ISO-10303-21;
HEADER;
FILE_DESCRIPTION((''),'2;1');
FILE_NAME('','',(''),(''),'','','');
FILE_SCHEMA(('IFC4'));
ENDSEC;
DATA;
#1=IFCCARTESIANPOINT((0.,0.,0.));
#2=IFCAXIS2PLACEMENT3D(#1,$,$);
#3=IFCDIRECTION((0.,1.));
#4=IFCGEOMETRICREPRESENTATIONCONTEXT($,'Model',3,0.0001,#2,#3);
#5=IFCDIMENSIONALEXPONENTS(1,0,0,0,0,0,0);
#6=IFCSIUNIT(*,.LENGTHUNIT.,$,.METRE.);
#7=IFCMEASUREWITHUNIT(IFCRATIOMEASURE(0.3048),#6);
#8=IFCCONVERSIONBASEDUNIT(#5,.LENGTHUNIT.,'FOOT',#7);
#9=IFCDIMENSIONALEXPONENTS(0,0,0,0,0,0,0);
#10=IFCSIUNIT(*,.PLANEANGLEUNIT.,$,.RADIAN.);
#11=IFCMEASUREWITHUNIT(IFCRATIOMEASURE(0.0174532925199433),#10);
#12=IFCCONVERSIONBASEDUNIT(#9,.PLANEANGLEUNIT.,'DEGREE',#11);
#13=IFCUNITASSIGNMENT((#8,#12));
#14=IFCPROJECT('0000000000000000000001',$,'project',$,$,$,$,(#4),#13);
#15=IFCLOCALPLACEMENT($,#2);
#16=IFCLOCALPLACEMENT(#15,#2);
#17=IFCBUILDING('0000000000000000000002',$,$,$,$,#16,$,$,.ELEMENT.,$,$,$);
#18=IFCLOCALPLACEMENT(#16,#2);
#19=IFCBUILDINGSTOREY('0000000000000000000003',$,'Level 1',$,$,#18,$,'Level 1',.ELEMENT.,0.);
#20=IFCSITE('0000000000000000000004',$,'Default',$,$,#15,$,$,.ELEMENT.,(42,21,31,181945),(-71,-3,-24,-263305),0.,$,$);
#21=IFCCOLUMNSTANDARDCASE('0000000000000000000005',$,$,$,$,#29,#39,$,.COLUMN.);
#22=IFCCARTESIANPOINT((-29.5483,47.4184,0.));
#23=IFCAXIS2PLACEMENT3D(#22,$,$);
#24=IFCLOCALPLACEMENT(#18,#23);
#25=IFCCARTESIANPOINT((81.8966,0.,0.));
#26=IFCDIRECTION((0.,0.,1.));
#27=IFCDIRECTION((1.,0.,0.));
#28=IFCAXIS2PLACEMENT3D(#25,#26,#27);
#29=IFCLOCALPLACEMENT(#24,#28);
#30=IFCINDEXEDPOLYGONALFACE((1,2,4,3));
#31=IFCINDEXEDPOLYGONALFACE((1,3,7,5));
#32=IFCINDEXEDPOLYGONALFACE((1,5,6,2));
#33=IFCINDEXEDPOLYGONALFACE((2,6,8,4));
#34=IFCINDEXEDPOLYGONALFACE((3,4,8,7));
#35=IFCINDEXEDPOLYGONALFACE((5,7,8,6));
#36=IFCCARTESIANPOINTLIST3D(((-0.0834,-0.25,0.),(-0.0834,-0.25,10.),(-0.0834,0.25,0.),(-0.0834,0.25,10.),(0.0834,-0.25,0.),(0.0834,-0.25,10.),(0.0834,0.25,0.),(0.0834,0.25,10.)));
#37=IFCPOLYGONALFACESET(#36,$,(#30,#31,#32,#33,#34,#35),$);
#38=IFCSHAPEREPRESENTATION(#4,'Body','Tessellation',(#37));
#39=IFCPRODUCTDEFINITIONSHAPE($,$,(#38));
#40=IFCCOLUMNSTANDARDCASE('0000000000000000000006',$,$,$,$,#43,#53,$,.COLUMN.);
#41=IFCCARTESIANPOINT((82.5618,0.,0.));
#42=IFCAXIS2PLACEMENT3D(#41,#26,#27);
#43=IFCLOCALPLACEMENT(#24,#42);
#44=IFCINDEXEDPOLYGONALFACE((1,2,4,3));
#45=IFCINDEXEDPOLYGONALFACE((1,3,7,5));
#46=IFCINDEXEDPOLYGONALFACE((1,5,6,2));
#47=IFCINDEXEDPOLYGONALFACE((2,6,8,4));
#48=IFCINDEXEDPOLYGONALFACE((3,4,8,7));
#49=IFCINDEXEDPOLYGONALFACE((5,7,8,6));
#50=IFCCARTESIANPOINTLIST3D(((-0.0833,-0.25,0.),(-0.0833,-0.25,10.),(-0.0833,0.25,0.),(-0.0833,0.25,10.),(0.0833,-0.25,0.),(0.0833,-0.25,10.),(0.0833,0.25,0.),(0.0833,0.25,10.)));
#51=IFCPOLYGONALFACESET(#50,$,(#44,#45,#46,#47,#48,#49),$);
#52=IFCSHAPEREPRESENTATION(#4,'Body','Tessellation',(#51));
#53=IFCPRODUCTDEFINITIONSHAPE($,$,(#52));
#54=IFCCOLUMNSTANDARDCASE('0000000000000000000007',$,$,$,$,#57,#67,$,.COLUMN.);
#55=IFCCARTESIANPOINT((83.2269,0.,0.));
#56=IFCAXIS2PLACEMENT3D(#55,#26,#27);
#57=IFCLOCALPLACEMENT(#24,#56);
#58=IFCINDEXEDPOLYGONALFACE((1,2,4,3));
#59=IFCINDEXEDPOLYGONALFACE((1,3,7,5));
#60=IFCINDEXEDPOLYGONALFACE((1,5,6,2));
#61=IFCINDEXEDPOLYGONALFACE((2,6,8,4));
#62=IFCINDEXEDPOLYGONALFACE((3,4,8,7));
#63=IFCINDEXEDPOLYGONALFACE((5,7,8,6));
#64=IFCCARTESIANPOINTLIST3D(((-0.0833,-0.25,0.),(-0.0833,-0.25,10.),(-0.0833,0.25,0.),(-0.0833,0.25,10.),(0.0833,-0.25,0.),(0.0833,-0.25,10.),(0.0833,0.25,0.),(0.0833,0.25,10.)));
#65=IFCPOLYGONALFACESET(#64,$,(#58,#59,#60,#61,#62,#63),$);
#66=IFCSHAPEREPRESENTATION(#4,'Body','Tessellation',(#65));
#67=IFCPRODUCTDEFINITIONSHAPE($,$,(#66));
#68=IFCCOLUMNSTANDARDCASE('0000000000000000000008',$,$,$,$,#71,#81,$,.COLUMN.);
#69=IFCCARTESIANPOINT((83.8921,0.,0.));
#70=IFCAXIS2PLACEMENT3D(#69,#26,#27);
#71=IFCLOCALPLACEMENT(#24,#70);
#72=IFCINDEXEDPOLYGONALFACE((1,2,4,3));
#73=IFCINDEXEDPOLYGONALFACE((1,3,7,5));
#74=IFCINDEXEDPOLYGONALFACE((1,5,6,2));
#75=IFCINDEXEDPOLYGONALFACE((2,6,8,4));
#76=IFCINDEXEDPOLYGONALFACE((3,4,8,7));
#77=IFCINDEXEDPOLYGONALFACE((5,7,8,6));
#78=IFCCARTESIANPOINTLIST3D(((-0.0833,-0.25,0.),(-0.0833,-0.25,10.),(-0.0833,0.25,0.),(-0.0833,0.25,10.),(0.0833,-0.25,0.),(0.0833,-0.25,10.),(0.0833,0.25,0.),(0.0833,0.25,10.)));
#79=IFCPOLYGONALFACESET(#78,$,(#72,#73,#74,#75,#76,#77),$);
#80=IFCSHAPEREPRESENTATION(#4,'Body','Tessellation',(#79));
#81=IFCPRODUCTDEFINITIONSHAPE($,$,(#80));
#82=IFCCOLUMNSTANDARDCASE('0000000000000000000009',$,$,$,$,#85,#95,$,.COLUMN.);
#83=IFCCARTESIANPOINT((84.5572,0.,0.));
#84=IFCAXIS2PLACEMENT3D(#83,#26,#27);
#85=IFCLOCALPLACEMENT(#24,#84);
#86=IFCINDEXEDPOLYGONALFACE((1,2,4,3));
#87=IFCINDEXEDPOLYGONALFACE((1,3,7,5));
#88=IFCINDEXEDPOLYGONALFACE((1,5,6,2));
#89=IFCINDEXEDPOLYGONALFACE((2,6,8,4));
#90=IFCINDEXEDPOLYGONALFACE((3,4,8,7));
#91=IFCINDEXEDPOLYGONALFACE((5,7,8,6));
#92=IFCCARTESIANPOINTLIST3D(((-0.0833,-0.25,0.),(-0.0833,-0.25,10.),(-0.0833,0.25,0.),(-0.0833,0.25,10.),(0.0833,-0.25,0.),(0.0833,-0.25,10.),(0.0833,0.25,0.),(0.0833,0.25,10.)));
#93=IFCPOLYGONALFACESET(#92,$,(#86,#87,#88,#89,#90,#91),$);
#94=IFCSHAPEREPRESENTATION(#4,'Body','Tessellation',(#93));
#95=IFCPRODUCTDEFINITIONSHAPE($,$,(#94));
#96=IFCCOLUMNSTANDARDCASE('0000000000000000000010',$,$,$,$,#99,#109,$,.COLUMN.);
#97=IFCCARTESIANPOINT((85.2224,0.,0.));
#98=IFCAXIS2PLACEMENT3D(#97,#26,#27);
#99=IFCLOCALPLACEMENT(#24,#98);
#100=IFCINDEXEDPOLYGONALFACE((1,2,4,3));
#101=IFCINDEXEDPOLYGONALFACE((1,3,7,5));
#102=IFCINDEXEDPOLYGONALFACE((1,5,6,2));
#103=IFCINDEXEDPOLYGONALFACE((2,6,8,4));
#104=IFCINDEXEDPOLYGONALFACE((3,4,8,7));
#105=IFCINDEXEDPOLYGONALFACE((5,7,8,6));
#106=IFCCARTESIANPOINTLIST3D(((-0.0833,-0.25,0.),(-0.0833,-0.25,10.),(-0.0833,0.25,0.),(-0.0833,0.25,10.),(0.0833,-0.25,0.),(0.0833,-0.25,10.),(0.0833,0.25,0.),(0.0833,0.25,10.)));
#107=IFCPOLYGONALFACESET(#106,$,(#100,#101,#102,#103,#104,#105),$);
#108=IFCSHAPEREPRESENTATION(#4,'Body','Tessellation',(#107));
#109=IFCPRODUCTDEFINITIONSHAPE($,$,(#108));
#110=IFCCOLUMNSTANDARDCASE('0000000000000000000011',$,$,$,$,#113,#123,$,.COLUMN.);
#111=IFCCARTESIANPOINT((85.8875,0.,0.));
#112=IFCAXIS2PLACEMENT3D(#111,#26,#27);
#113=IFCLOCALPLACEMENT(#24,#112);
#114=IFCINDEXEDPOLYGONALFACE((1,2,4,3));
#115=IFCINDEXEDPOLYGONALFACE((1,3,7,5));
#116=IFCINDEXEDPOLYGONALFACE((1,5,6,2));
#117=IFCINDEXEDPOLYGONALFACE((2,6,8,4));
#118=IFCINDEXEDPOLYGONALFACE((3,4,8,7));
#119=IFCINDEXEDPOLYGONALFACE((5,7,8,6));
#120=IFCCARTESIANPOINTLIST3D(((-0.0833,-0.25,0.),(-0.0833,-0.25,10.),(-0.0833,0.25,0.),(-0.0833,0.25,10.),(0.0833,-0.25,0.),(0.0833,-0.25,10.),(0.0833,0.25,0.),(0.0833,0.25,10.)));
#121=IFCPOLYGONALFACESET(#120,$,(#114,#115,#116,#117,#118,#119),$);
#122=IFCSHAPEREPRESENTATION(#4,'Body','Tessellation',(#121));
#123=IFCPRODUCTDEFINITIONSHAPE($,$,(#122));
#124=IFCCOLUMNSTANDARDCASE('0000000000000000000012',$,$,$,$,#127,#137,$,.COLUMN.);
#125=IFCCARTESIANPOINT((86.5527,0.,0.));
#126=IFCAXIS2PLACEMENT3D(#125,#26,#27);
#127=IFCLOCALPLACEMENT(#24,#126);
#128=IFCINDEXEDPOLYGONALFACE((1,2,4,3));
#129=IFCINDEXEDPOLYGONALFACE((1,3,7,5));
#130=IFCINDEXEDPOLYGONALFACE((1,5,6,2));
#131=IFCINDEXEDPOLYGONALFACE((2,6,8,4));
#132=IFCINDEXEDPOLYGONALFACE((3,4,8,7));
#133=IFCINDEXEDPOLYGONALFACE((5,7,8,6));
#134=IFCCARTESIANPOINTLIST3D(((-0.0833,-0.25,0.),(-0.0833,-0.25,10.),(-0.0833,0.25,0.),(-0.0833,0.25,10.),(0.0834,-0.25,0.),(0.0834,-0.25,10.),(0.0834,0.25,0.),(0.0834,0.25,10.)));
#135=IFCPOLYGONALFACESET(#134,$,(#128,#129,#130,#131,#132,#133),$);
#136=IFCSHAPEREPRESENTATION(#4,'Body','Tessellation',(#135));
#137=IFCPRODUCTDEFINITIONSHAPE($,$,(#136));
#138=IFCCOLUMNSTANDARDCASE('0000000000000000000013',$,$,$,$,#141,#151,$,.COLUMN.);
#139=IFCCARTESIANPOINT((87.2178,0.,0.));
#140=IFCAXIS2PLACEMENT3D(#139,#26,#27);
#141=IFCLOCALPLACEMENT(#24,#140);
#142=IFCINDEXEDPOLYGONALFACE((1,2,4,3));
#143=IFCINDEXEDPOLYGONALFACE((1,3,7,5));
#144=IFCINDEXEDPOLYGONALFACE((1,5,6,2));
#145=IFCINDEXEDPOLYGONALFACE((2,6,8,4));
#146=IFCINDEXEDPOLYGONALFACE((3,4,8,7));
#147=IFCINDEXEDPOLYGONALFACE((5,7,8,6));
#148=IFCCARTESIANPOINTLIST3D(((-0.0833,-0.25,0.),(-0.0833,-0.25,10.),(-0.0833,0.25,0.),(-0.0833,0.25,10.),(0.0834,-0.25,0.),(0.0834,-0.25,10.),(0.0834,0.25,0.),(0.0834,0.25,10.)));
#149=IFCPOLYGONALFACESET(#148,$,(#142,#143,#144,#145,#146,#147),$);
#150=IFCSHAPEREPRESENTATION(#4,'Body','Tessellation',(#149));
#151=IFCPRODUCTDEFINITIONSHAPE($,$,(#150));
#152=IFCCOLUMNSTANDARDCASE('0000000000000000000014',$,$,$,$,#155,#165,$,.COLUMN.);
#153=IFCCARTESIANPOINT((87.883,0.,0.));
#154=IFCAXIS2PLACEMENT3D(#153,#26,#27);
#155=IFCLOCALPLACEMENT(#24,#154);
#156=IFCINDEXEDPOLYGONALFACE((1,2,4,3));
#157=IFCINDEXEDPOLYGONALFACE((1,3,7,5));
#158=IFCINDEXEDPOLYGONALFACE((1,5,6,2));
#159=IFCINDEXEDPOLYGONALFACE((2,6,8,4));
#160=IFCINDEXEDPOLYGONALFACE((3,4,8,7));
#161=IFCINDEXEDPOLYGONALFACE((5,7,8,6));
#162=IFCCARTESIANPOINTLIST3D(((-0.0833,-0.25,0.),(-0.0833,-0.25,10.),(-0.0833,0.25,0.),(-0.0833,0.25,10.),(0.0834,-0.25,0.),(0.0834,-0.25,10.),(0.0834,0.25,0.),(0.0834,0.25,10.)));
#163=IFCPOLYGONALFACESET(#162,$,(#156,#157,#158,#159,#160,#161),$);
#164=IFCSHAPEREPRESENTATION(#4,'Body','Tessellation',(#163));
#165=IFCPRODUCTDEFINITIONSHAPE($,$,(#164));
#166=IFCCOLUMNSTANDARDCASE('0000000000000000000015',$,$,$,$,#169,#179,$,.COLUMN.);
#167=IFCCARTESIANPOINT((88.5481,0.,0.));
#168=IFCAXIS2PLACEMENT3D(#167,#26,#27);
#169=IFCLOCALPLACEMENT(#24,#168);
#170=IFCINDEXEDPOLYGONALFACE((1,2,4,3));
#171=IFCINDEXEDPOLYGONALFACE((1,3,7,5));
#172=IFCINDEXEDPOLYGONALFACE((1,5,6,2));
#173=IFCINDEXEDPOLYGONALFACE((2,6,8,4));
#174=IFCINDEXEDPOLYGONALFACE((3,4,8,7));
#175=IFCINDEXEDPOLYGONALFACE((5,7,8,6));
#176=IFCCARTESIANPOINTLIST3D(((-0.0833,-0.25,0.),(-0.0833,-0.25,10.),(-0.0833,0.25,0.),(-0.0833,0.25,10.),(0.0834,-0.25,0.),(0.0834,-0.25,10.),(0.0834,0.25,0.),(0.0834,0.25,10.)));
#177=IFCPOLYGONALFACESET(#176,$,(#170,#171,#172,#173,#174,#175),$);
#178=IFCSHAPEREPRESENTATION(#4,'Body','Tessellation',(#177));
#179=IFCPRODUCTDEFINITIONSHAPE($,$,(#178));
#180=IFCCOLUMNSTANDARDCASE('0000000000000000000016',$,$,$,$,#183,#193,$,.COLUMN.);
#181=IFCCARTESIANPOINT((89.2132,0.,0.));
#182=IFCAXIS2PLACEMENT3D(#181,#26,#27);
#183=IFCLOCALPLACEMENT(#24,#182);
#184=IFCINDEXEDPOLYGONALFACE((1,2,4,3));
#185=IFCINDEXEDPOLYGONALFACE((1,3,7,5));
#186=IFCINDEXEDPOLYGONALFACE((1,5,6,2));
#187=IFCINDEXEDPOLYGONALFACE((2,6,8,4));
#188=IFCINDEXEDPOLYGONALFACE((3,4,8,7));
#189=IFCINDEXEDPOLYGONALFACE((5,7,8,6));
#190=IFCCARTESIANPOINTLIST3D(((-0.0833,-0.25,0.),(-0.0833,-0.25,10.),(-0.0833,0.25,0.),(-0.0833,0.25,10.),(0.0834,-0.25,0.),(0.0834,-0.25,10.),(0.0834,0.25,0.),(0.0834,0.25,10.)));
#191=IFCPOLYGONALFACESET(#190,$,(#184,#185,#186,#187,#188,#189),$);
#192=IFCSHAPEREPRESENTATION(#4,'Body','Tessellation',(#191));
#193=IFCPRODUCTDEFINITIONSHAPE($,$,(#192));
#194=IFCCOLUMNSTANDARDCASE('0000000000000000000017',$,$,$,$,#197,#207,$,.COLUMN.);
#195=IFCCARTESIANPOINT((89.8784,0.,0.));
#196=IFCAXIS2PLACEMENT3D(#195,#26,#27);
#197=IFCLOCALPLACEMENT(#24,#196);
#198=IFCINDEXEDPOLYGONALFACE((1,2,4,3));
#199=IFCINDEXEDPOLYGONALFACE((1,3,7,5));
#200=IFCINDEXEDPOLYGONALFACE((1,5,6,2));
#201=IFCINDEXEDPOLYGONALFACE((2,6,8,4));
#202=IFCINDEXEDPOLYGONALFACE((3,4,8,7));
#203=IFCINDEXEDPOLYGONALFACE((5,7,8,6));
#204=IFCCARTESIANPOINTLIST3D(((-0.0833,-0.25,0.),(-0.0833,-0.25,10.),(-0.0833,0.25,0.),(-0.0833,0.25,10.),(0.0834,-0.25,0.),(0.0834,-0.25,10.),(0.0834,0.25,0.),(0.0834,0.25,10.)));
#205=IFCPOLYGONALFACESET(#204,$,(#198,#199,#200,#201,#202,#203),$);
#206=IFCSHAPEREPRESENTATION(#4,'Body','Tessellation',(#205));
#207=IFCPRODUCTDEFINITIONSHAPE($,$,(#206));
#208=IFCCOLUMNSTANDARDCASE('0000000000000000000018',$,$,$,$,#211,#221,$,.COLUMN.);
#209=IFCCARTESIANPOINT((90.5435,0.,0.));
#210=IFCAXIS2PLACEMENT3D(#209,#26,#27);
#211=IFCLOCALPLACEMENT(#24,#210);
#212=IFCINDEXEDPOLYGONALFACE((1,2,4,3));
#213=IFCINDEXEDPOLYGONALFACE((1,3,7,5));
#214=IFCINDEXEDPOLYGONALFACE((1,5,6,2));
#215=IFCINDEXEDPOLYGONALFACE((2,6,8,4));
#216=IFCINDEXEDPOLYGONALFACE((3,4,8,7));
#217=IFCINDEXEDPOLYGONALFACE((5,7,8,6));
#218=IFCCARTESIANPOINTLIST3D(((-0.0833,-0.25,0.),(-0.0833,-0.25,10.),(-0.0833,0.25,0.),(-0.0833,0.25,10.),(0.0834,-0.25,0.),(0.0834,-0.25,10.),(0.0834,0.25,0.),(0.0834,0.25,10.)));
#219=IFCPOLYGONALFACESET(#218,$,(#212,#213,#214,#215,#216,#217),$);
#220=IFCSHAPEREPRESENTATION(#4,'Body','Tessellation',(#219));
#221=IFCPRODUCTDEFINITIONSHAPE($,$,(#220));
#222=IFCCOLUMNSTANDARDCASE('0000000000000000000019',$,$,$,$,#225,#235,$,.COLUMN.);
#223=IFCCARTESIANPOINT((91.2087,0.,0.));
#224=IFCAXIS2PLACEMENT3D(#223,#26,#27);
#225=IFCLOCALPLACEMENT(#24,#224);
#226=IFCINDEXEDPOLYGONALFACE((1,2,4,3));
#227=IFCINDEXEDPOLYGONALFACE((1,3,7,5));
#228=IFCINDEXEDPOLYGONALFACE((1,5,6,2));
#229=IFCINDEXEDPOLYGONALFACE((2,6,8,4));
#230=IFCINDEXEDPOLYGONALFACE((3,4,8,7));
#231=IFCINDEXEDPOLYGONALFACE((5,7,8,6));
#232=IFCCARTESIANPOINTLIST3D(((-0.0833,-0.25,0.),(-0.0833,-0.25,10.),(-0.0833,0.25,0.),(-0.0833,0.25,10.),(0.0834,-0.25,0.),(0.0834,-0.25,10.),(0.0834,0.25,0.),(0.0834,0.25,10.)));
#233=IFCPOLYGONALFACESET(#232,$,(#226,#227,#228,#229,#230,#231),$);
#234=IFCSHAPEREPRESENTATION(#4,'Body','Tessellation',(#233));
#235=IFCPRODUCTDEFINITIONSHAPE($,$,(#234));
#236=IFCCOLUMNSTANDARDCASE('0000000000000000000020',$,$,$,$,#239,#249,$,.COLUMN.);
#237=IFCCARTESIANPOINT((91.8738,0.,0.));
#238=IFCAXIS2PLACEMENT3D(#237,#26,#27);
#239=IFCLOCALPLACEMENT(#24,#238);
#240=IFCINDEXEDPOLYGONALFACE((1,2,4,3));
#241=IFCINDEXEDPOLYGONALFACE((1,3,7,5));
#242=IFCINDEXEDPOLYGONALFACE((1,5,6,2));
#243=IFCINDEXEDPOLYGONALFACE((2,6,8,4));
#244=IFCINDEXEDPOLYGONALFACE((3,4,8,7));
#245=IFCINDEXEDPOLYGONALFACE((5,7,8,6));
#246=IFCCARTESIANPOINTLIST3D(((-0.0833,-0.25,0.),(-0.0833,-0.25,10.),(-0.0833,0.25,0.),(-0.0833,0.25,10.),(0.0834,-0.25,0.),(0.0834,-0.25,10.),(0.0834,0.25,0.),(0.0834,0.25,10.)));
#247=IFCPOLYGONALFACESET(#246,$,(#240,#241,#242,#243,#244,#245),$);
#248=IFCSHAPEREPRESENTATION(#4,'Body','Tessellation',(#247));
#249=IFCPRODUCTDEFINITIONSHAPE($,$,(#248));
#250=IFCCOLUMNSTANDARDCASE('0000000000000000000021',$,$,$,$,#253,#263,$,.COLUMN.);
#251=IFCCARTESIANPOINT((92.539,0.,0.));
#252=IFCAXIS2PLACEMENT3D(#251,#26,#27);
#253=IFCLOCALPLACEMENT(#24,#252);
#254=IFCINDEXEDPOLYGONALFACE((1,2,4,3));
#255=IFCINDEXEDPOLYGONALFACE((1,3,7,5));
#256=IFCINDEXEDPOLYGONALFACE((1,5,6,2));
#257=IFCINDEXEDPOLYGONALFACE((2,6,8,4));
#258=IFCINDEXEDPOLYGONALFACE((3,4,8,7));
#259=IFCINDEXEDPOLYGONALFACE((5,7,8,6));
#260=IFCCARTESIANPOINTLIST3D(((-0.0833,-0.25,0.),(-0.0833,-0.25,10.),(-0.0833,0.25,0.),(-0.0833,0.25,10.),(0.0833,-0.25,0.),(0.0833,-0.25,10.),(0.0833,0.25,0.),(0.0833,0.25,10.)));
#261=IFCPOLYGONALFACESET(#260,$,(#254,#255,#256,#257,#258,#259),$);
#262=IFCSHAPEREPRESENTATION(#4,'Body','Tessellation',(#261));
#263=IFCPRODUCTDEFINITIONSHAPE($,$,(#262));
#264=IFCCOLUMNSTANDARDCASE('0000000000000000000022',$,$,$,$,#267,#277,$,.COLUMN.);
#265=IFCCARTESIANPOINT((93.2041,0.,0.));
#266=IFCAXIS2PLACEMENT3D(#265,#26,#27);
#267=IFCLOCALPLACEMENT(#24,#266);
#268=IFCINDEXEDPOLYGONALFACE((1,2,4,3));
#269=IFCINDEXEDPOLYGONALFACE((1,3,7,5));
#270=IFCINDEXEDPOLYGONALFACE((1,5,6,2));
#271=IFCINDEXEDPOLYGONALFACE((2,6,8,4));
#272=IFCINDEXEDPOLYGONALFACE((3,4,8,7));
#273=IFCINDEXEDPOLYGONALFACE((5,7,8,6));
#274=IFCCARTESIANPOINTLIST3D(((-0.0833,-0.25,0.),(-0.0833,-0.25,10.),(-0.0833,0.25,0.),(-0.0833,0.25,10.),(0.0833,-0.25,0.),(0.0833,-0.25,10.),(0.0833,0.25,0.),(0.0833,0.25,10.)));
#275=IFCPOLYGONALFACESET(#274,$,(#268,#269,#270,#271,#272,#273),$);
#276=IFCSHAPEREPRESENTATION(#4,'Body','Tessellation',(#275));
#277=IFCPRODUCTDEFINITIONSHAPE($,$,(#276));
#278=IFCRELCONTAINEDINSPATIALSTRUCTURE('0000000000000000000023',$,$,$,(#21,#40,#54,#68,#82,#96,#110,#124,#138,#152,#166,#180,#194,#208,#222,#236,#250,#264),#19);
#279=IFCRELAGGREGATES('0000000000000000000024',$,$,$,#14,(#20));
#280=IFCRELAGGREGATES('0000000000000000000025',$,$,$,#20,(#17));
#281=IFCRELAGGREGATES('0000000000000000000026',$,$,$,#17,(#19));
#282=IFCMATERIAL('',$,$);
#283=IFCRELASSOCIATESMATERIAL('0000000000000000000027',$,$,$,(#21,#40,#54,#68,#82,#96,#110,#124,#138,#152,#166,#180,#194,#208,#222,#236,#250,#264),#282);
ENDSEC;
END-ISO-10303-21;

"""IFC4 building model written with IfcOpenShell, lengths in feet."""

from ifc_helpers import new_model, entity, si_unit, converted_unit, direction, frame, origin, place, context, project, spatial, rectangle, extrude, material, element, save


model = new_model("IFC4")

# Units and contexts
model_context = context("Model", 3, precision=0.0001, world=origin(), true_north=direction((0.0, 1.0)))
ifc_project = project(units=[converted_unit("LENGTHUNIT", "FOOT", entity("IfcRatioMeasure", 0.3048), si_unit("LENGTHUNIT", "METRE"), dimensions=[1, 0, 0, 0, 0, 0, 0]), converted_unit("PLANEANGLEUNIT", "DEGREE", entity("IfcRatioMeasure", 0.0174532925199433), si_unit("PLANEANGLEUNIT", "RADIAN"), dimensions=[0, 0, 0, 0, 0, 0, 0])], contexts=[model_context])

# Site, building, storey
site_placement = place(None, origin())
site = spatial("IfcSite", under=ifc_project, at=site_placement, Name="Default", CompositionType="ELEMENT", RefLatitude=(42, 21, 31, 181945), RefLongitude=(-71, -3, -24, -263305), RefElevation=0.0)
building_placement = place(site_placement, origin())
building = spatial("IfcBuilding", under=site, at=building_placement, CompositionType="ELEMENT")
storey_placement = place(building_placement, origin())
storey = spatial("IfcBuildingStorey", under=building, at=storey_placement, Name="Level 1", LongName="Level 1", CompositionType="ELEMENT", Elevation=0.0)

# Columns
ifc_material = material(Name="")
placement = place(storey_placement, frame((-29.5483, 47.4184, 0.0)))
for number, where, z_axis, x_axis in (
    (1, (81.8966, 0.0, 0.0), (0.0, 0.0, 1.0), (1.0, 0.0, 0.0)),
    (2, (82.5618, 0.0, 0.0), (0.0, 0.0, 1.0), (1.0, 0.0, 0.0)),
    (3, (83.2269, 0.0, 0.0), (0.0, 0.0, 1.0), (1.0, 0.0, 0.0)),
    (4, (83.8921, 0.0, 0.0), (0.0, 0.0, 1.0), (1.0, 0.0, 0.0)),
    (5, (84.5572, 0.0, 0.0), (0.0, 0.0, 1.0), (1.0, 0.0, 0.0)),
    (6, (85.2224, 0.0, 0.0), (0.0, 0.0, 1.0), (1.0, 0.0, 0.0)),
    (7, (85.8875, 0.0, 0.0), (0.0, 0.0, 1.0), (1.0, 0.0, 0.0)),
    (8, (86.5527, 0.0, 0.0), (0.0, 0.0, 1.0), (1.0, 0.0, 0.0)),
    (9, (87.2178, 0.0, 0.0), (0.0, 0.0, 1.0), (1.0, 0.0, 0.0)),
    (10, (87.883, 0.0, 0.0), (0.0, 0.0, 1.0), (1.0, 0.0, 0.0)),
    (11, (88.5481, 0.0, 0.0), (0.0, 0.0, 1.0), (1.0, 0.0, 0.0)),
    (12, (89.2132, 0.0, 0.0), (0.0, 0.0, 1.0), (1.0, 0.0, 0.0)),
    (13, (89.8784, 0.0, 0.0), (0.0, 0.0, 1.0), (1.0, 0.0, 0.0)),
    (14, (90.5435, 0.0, 0.0), (0.0, 0.0, 1.0), (1.0, 0.0, 0.0)),
    (15, (91.2087, 0.0, 0.0), (0.0, 0.0, 1.0), (1.0, 0.0, 0.0)),
    (16, (91.8738, 0.0, 0.0), (0.0, 0.0, 1.0), (1.0, 0.0, 0.0)),
    (17, (92.539, 0.0, 0.0), (0.0, 0.0, 1.0), (1.0, 0.0, 0.0)),
    (18, (93.2041, 0.0, 0.0), (0.0, 0.0, 1.0), (1.0, 0.0, 0.0)),
):
    element("IfcColumnStandardCase", number, at=place(placement, frame(where, z_axis=z_axis, x_axis=x_axis)), inside=storey, material=ifc_material, PredefinedType="COLUMN", context=model_context, shape_type="SweptSolid", body=[
        extrude(rectangle(XDim=0.1667, YDim=0.5), origin(), (0.0, 0.0, 1.0), 10.0),
    ])

save(model, "model.ifc")
